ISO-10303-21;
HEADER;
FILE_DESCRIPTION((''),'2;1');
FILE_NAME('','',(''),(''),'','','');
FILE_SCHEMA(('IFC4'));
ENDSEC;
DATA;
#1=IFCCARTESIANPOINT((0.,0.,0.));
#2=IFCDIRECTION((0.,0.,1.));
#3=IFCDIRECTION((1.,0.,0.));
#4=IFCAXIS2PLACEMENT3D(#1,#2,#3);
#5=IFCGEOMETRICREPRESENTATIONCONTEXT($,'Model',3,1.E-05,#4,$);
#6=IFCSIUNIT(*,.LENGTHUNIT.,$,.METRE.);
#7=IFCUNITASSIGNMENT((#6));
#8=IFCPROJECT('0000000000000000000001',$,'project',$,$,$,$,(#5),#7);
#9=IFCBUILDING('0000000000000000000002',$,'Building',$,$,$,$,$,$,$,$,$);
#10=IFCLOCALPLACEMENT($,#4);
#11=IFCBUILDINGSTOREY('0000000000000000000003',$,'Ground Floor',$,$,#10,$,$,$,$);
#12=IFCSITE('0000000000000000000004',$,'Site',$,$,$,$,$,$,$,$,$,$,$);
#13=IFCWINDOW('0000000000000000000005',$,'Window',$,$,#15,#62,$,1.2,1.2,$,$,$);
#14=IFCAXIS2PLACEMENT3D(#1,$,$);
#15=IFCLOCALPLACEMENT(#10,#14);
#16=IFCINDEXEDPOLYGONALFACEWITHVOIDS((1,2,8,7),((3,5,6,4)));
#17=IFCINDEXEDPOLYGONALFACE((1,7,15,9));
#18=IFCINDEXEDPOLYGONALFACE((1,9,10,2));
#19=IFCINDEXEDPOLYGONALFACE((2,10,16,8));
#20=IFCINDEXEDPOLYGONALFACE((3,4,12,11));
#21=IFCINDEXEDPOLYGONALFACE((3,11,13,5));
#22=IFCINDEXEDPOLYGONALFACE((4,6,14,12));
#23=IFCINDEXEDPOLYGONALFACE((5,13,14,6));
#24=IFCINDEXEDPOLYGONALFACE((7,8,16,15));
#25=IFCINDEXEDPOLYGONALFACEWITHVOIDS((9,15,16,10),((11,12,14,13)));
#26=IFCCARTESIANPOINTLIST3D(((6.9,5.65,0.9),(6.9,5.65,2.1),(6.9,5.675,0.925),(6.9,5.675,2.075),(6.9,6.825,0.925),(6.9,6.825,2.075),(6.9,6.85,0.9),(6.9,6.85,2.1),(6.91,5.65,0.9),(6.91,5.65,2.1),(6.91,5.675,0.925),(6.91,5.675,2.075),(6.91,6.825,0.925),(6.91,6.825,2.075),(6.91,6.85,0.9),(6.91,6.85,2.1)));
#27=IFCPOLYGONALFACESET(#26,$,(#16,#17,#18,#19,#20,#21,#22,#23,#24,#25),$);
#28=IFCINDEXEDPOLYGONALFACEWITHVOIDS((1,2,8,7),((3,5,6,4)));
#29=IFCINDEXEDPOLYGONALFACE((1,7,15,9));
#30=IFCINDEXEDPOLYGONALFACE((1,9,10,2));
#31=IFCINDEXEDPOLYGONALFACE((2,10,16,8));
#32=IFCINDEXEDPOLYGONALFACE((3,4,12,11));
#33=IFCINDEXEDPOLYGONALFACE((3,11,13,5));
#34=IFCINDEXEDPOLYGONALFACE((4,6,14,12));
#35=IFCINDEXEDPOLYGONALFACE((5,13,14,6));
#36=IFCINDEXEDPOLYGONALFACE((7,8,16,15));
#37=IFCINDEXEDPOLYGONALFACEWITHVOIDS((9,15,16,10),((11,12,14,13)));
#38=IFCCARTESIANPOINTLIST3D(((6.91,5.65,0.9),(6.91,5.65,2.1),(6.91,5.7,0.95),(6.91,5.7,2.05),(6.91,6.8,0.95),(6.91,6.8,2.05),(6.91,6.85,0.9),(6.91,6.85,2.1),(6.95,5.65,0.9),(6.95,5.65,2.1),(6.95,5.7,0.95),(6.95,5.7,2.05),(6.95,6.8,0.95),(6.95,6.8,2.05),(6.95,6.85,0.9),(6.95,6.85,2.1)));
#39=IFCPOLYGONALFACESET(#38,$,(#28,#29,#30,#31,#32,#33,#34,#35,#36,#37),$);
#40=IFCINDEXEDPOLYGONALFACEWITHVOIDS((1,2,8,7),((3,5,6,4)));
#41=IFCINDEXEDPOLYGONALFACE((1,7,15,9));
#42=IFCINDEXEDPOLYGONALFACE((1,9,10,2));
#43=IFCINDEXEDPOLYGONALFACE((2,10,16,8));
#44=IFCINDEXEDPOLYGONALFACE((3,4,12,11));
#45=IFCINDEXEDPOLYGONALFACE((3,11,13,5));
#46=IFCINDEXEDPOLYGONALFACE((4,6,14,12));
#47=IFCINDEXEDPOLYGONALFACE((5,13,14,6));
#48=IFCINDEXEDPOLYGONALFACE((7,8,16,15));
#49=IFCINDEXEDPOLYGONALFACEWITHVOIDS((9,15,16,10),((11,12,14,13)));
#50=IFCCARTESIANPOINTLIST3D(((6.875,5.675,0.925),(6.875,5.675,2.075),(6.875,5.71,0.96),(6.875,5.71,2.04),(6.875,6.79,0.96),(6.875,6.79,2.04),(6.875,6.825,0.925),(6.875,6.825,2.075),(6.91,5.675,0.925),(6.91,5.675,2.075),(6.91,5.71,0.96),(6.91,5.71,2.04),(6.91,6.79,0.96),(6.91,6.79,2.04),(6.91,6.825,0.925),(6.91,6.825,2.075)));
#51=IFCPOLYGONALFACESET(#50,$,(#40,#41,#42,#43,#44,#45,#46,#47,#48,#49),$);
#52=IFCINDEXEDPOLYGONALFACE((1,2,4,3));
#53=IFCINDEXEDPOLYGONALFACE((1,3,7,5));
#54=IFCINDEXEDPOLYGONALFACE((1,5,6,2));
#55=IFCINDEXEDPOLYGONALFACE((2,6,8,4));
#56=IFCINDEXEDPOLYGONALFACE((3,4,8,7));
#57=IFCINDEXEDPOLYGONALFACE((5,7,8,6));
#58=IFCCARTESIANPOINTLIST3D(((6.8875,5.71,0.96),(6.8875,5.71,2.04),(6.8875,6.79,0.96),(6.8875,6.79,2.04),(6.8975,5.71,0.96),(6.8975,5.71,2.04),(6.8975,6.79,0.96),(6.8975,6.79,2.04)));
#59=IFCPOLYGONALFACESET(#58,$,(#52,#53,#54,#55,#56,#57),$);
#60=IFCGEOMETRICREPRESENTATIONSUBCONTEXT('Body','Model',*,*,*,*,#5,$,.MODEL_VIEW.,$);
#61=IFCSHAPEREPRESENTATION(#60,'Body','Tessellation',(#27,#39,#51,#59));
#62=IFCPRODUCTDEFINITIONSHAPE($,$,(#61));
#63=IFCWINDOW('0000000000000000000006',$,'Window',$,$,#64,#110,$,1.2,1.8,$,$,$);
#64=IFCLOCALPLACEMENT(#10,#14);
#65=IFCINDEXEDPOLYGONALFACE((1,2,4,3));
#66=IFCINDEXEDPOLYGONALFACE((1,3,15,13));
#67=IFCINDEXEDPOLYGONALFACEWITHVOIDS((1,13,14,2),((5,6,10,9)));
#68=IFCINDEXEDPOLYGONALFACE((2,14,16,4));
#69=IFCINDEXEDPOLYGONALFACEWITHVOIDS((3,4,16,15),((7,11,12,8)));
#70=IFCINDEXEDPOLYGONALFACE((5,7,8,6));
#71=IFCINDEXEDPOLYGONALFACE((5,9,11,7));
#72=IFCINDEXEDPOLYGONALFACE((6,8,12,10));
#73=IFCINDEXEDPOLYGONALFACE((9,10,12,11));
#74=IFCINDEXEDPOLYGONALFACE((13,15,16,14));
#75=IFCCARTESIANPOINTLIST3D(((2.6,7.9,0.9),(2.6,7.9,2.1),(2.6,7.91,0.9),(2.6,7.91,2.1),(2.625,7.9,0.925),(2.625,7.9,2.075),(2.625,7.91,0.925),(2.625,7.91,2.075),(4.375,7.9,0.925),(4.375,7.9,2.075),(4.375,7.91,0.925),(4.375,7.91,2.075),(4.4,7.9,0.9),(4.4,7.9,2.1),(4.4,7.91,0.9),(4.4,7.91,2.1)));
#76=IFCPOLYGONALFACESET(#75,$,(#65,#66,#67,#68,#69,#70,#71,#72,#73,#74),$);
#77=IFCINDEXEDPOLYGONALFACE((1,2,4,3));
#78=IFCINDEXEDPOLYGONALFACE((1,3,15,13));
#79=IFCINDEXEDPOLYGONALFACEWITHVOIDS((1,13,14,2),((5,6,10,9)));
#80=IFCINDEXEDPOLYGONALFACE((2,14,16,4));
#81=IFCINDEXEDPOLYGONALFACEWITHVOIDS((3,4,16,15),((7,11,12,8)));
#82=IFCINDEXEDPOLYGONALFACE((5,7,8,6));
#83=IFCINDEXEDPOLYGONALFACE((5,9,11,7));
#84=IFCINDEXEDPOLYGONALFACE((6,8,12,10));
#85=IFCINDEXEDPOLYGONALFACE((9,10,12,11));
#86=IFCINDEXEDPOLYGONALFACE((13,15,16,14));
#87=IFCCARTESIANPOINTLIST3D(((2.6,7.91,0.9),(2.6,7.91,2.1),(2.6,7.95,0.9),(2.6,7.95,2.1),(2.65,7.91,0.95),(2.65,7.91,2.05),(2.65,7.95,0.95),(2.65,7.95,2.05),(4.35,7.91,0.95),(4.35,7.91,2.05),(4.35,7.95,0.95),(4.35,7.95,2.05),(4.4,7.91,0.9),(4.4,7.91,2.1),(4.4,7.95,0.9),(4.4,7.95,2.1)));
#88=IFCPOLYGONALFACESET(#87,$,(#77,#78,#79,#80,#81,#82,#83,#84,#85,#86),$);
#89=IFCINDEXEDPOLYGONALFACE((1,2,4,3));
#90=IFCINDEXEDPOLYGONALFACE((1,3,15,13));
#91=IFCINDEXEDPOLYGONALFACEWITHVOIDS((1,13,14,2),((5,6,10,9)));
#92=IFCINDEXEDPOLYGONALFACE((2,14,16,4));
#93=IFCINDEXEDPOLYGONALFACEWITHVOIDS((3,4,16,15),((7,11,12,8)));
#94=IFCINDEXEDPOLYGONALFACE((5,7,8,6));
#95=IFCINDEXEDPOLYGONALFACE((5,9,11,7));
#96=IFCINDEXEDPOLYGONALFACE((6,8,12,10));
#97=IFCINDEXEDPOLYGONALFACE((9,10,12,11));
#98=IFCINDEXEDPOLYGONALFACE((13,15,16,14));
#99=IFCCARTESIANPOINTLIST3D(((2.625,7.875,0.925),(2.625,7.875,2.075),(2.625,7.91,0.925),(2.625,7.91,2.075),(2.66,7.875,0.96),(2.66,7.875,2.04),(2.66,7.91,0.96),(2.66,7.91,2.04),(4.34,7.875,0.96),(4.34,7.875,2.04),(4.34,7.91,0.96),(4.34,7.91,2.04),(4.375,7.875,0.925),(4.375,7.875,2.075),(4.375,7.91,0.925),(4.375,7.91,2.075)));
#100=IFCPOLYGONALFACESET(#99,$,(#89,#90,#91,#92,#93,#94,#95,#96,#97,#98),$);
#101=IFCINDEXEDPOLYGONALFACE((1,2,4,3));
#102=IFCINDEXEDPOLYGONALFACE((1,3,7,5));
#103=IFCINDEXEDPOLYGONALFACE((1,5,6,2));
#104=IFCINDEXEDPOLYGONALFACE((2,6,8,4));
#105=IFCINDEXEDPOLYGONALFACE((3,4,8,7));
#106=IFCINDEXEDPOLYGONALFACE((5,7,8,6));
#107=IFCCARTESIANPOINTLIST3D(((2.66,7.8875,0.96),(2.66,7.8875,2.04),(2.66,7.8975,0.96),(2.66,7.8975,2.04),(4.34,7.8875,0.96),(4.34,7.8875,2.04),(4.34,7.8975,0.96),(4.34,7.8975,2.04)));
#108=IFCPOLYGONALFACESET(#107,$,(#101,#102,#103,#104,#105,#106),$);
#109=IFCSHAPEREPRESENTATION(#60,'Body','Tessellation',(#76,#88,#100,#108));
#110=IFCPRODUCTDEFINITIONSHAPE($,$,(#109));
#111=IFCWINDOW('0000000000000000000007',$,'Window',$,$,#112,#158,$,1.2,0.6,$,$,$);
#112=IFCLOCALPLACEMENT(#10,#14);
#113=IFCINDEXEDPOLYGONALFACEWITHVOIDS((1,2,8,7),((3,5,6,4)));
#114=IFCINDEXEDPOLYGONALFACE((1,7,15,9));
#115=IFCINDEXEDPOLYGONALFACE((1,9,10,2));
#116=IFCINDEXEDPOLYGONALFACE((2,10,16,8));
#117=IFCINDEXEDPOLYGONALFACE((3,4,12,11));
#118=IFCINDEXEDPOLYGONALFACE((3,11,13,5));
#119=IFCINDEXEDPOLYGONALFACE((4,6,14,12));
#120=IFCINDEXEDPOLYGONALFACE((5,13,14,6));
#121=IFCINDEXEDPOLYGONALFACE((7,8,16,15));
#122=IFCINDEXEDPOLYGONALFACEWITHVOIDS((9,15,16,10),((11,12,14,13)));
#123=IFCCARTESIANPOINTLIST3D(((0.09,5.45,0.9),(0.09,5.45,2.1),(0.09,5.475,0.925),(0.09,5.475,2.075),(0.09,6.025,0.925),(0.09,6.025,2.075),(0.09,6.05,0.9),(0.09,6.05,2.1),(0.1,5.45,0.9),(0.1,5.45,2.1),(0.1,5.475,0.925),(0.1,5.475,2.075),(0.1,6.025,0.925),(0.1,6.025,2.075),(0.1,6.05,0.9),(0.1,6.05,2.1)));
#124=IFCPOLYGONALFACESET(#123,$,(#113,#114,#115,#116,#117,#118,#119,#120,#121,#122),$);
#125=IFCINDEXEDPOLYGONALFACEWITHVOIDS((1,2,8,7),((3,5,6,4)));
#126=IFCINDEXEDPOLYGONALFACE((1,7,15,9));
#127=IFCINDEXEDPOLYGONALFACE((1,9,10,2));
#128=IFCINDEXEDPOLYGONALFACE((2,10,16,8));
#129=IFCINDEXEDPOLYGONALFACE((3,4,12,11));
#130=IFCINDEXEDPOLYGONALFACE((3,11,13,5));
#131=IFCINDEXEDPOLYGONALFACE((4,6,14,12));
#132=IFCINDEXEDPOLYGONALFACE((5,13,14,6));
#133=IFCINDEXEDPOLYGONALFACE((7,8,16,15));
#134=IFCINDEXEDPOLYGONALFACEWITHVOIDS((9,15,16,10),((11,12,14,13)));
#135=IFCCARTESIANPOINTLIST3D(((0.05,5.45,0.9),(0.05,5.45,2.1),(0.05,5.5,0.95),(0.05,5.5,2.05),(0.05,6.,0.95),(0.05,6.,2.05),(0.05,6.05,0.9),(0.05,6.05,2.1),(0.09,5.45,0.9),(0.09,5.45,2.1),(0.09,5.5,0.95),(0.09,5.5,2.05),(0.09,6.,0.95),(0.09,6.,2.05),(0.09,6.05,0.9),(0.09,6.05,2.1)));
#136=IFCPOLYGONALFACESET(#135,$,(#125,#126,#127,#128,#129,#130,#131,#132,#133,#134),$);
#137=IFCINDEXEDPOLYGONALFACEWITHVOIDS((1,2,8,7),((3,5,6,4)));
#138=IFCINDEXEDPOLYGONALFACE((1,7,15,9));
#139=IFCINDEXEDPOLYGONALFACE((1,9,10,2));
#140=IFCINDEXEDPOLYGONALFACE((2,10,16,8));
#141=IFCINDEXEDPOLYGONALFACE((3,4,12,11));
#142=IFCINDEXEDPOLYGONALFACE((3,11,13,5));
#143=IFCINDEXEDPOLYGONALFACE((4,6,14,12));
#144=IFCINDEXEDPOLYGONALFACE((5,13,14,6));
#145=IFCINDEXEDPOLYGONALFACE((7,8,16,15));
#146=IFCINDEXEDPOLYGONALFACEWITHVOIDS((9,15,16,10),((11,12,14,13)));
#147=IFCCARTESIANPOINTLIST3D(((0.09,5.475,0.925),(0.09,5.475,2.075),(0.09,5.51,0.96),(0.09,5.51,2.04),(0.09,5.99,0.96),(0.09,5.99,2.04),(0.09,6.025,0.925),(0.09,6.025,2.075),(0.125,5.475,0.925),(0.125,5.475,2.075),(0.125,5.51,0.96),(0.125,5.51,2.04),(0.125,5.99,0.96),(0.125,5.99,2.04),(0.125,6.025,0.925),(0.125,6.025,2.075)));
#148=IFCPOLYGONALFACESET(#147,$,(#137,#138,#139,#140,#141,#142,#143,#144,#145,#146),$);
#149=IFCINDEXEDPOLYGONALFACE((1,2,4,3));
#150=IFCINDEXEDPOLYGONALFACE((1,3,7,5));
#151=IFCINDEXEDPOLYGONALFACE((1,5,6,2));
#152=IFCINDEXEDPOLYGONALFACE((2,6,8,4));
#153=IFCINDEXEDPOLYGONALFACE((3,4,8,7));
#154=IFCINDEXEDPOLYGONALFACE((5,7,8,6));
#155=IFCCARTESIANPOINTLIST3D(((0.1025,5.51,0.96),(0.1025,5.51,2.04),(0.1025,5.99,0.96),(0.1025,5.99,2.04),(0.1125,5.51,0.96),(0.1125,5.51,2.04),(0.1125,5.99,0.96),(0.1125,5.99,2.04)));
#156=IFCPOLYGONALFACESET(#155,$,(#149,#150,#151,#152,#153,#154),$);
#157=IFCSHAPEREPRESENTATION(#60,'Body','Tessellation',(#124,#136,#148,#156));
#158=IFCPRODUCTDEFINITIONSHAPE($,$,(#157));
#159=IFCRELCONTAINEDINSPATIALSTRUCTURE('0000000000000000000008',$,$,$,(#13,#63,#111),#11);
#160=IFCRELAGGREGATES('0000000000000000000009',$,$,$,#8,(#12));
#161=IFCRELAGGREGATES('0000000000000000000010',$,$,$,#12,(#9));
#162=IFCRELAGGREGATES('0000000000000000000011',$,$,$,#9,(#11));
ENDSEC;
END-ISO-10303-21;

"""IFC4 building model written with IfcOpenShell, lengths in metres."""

from ifc_helpers import new_model, si_unit, frame, origin_with_axes, place, context, subcontext, project, spatial, line, indexed_curve, outline, extrude, element, save


model = new_model("IFC4")

# Units and contexts
model_context = context("Model", 3, precision=1e-05, world=origin_with_axes())
body_context = subcontext(model_context, "Body", "Model", "MODEL_VIEW")
ifc_project = project(units=[si_unit("LENGTHUNIT", "METRE")], contexts=[model_context])

# Site, building, storey
site = spatial("IfcSite", under=ifc_project, Name="Site")
building = spatial("IfcBuilding", under=site, Name="Building")
storey_placement = place(None, origin_with_axes())
storey = spatial("IfcBuildingStorey", under=building, at=storey_placement, Name="Ground Floor")

# Windows
window_1_placement = place(storey_placement, frame((7.0, 5.65, 0.9), z_axis=(0.0, 0.0, 1.0), x_axis=(0.0, 1.0, 0.0)))
element("IfcWindow", 1, at=window_1_placement, inside=storey, Name="Window", OverallHeight=1.2, OverallWidth=1.2, context=body_context, shape_type="SweptSolid", body=[
    extrude(outline(indexed_curve([(0.0, 0.0), (1.2, 0.0), (1.2, 1.2), (0.0, 1.2)], segments=[line(1, 2, 3, 4, 1)]), holes=[indexed_curve([(0.025, 0.025), (1.175, 0.025), (1.175, 1.175), (0.025, 1.175)], segments=[line(1, 2, 3, 4, 1)])]), frame((0.0, 0.09, 0.0), z_axis=(0.0, -1.0, 0.0), x_axis=(1.0, 0.0, 0.0)), (0.0, 0.0, -1.0), 0.01),
    extrude(outline(indexed_curve([(0.0, 0.0), (1.2, 0.0), (1.2, 1.2), (0.0, 1.2)], segments=[line(1, 2, 3, 4, 1)]), holes=[indexed_curve([(0.05, 0.05), (1.15, 0.05), (1.15, 1.15), (0.05, 1.15)], segments=[line(1, 2, 3, 4, 1)])]), frame((0.0, 0.05, 0.0), z_axis=(0.0, -1.0, 0.0), x_axis=(1.0, 0.0, 0.0)), (0.0, 0.0, -1.0), 0.04),
    extrude(outline(indexed_curve([(0.0, 0.0), (1.15, 0.0), (1.15, 1.15), (0.0, 1.15)], segments=[line(1, 2, 3, 4, 1)]), holes=[indexed_curve([(0.035, 0.035), (1.115, 0.035), (1.115, 1.115), (0.035, 1.115)], segments=[line(1, 2, 3, 4, 1)])]), frame((0.025, 0.09, 0.025), z_axis=(0.0, -1.0, 0.0), x_axis=(1.0, 0.0, 0.0)), (0.0, 0.0, -1.0), 0.035),
    extrude(outline(indexed_curve([(0.035, 0.035), (1.115, 0.035), (1.115, 1.115), (0.035, 1.115)], segments=[line(1, 2, 3, 4, 1)])), frame((0.025, 0.1025, 0.025), z_axis=(0.0, -1.0, 0.0), x_axis=(1.0, 0.0, 0.0)), (0.0, 0.0, -1.0), 0.01),
])
window_2_placement = place(storey_placement, frame((4.4, 8.0, 0.9), z_axis=(0.0, 0.0, 1.0), x_axis=(-1.0, 0.0, 0.0)))
element("IfcWindow", 2, at=window_2_placement, inside=storey, Name="Window", OverallHeight=1.2, OverallWidth=1.8, context=body_context, shape_type="SweptSolid", body=[
    extrude(outline(indexed_curve([(0.0, 0.0), (1.8, 0.0), (1.8, 1.2), (0.0, 1.2)], segments=[line(1, 2, 3, 4, 1)]), holes=[indexed_curve([(0.025, 0.025), (1.775, 0.025), (1.775, 1.175), (0.025, 1.175)], segments=[line(1, 2, 3, 4, 1)])]), frame((0.0, 0.09, 0.0), z_axis=(0.0, -1.0, 0.0), x_axis=(1.0, 0.0, 0.0)), (0.0, 0.0, -1.0), 0.01),
    extrude(outline(indexed_curve([(0.0, 0.0), (1.8, 0.0), (1.8, 1.2), (0.0, 1.2)], segments=[line(1, 2, 3, 4, 1)]), holes=[indexed_curve([(0.05, 0.05), (1.75, 0.05), (1.75, 1.15), (0.05, 1.15)], segments=[line(1, 2, 3, 4, 1)])]), frame((0.0, 0.05, 0.0), z_axis=(0.0, -1.0, 0.0), x_axis=(1.0, 0.0, 0.0)), (0.0, 0.0, -1.0), 0.04),
    extrude(outline(indexed_curve([(0.0, 0.0), (1.75, 0.0), (1.75, 1.15), (0.0, 1.15)], segments=[line(1, 2, 3, 4, 1)]), holes=[indexed_curve([(0.035, 0.035), (1.715, 0.035), (1.715, 1.115), (0.035, 1.115)], segments=[line(1, 2, 3, 4, 1)])]), frame((0.025, 0.09, 0.025), z_axis=(0.0, -1.0, 0.0), x_axis=(1.0, 0.0, 0.0)), (0.0, 0.0, -1.0), 0.035),
    extrude(outline(indexed_curve([(0.035, 0.035), (1.715, 0.035), (1.715, 1.115), (0.035, 1.115)], segments=[line(1, 2, 3, 4, 1)])), frame((0.025, 0.1025, 0.025), z_axis=(0.0, -1.0, 0.0), x_axis=(1.0, 0.0, 0.0)), (0.0, 0.0, -1.0), 0.01),
])
window_3_placement = place(storey_placement, frame((0.0, 6.05, 0.9), z_axis=(0.0, 0.0, 1.0), x_axis=(0.0, -1.0, 0.0)))
element("IfcWindow", 3, at=window_3_placement, inside=storey, Name="Window", OverallHeight=1.2, OverallWidth=0.6, context=body_context, shape_type="SweptSolid", body=[
    extrude(outline(indexed_curve([(0.0, 0.0), (0.6, 0.0), (0.6, 1.2), (0.0, 1.2)], segments=[line(1, 2, 3, 4, 1)]), holes=[indexed_curve([(0.025, 0.025), (0.575, 0.025), (0.575, 1.175), (0.025, 1.175)], segments=[line(1, 2, 3, 4, 1)])]), frame((0.0, 0.09, 0.0), z_axis=(0.0, -1.0, 0.0), x_axis=(1.0, 0.0, 0.0)), (0.0, 0.0, -1.0), 0.01),
    extrude(outline(indexed_curve([(0.0, 0.0), (0.6, 0.0), (0.6, 1.2), (0.0, 1.2)], segments=[line(1, 2, 3, 4, 1)]), holes=[indexed_curve([(0.05, 0.05), (0.55, 0.05), (0.55, 1.15), (0.05, 1.15)], segments=[line(1, 2, 3, 4, 1)])]), frame((0.0, 0.05, 0.0), z_axis=(0.0, -1.0, 0.0), x_axis=(1.0, 0.0, 0.0)), (0.0, 0.0, -1.0), 0.04),
    extrude(outline(indexed_curve([(0.0, 0.0), (0.55, 0.0), (0.55, 1.15), (0.0, 1.15)], segments=[line(1, 2, 3, 4, 1)]), holes=[indexed_curve([(0.035, 0.035), (0.515, 0.035), (0.515, 1.115), (0.035, 1.115)], segments=[line(1, 2, 3, 4, 1)])]), frame((0.025, 0.09, 0.025), z_axis=(0.0, -1.0, 0.0), x_axis=(1.0, 0.0, 0.0)), (0.0, 0.0, -1.0), 0.035),
    extrude(outline(indexed_curve([(0.035, 0.035), (0.515, 0.035), (0.515, 1.115), (0.035, 1.115)], segments=[line(1, 2, 3, 4, 1)])), frame((0.025, 0.1025, 0.025), z_axis=(0.0, -1.0, 0.0), x_axis=(1.0, 0.0, 0.0)), (0.0, 0.0, -1.0), 0.01),
])

save(model, "model.ifc")
